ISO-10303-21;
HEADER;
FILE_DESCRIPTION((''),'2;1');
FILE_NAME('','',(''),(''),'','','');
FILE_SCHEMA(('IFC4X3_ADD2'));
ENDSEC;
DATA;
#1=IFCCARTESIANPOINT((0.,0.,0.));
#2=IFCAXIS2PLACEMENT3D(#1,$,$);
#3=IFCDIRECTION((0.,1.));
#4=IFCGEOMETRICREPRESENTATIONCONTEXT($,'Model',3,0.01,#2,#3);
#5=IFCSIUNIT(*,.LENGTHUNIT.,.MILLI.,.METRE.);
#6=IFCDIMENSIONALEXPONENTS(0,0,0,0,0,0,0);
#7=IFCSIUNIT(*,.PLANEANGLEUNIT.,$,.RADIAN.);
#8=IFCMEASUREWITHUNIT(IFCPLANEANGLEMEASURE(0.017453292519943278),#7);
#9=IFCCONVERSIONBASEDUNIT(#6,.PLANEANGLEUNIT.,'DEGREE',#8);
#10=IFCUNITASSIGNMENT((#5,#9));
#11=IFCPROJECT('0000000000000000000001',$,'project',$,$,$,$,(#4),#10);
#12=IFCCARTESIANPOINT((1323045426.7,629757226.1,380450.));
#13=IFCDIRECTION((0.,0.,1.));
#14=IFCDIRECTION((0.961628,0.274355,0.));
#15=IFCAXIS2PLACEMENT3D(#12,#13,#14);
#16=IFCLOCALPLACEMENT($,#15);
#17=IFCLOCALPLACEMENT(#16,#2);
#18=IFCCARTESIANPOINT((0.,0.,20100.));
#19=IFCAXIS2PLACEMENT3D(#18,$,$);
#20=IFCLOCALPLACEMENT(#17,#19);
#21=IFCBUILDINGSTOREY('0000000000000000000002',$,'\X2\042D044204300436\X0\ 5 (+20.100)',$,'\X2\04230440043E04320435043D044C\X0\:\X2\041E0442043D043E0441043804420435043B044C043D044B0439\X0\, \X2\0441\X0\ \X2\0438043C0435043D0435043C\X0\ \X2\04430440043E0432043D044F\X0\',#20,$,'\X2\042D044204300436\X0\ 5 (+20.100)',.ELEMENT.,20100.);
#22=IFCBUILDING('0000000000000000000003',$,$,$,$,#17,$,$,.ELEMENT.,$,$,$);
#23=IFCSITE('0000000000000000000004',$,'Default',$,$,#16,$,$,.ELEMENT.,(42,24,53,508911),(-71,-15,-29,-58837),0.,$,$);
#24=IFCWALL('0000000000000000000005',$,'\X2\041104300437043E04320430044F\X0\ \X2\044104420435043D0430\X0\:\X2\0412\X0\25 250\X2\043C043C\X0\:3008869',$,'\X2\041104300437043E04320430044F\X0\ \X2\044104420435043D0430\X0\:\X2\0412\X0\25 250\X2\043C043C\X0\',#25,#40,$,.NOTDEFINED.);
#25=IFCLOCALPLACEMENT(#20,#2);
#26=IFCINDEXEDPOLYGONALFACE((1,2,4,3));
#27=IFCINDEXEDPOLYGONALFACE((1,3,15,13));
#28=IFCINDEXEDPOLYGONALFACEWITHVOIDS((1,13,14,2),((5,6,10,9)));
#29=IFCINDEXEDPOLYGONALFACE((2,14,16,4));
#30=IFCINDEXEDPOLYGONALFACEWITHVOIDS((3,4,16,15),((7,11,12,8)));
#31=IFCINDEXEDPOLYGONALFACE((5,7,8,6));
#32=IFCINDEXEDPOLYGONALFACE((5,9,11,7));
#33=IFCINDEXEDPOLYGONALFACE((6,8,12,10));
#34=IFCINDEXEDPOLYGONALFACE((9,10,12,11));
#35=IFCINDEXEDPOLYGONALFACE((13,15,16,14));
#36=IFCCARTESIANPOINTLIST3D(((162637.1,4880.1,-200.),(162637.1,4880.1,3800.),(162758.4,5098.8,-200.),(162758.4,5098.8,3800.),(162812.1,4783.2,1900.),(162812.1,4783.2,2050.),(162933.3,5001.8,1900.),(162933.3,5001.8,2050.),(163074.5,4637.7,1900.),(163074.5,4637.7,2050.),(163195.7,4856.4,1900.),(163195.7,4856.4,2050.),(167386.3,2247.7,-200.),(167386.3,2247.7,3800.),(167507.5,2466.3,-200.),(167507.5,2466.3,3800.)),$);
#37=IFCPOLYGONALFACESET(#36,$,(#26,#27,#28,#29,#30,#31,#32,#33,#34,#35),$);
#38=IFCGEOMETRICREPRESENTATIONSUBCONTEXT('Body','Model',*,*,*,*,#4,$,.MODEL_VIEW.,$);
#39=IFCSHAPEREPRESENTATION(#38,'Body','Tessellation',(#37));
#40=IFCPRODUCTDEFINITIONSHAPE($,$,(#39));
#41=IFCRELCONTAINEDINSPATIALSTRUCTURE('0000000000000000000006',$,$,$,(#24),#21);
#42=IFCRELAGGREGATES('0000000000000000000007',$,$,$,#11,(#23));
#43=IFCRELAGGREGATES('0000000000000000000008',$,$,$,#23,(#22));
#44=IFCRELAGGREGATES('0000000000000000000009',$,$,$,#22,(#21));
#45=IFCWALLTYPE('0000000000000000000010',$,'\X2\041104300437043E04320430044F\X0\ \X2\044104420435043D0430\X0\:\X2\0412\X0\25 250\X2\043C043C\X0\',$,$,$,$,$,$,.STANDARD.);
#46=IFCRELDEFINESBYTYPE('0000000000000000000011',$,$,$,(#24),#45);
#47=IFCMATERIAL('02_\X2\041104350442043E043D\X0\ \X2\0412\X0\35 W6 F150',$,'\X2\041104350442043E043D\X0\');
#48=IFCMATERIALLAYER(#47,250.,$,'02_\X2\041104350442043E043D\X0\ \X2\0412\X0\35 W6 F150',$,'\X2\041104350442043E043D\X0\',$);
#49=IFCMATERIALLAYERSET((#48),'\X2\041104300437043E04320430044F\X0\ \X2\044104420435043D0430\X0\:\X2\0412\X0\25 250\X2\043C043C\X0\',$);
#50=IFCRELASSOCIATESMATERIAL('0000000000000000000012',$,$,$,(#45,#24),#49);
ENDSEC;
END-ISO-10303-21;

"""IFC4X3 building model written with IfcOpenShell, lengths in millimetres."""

from ifc_helpers import new_model, entity, si_unit, converted_unit, direction, frame, frame_2d, origin, place, context, subcontext, project, spatial, rectangle, extrude, material, layer, layer_set, type_object, element, save


model = new_model("IFC4X3")

# Units and contexts
model_context = context("Model", 3, precision=0.01, world=origin(), true_north=direction((0.0, 1.0)))
body_context = subcontext(model_context, "Body", "Model", "MODEL_VIEW")
ifc_project = project(units=[si_unit("LENGTHUNIT", "METRE", prefix="MILLI"), converted_unit("PLANEANGLEUNIT", "DEGREE", entity("IfcPlaneAngleMeasure", 0.017453292519943278), si_unit("PLANEANGLEUNIT", "RADIAN"), dimensions=[0, 0, 0, 0, 0, 0, 0])], contexts=[model_context])

# Site, building, storey
site_placement = place(None, frame((1323045426.7, 629757226.1, 380450.0), z_axis=(0.0, 0.0, 1.0), x_axis=(0.961628, 0.274355, 0.0)))
site = spatial("IfcSite", under=ifc_project, at=site_placement, Name="Default", CompositionType="ELEMENT", RefLatitude=(42, 24, 53, 508911), RefLongitude=(-71, -15, -29, -58837), RefElevation=0.0)
building_placement = place(site_placement, origin())
building = spatial("IfcBuilding", under=site, at=building_placement, CompositionType="ELEMENT")
storey_placement = place(building_placement, frame((0.0, 0.0, 20100.0)))
storey = spatial("IfcBuildingStorey", under=building, at=storey_placement, Name="Этаж 5 (+20.100)", ObjectType="Уровень:Относительный, с именем уровня", LongName="Этаж 5 (+20.100)", CompositionType="ELEMENT", Elevation=20100.0)

# Shared definitions
ifc_material = material(Name="02_Бетон В35 W6 F150", Category="Бетон")
ifc_layer = layer(ifc_material, 250.0, Name="02_Бетон В35 W6 F150", Category="Бетон")
ifc_layer_set = layer_set([ifc_layer], Name="Базовая стена:В25 250мм")
wall_type = type_object("IfcWallType", Name="Базовая стена:В25 250мм", PredefinedType="STANDARD", material=ifc_layer_set)

# Wall, opening
wall_1_placement = place(storey_placement, frame((167446.9, 2357.0, -200.0), z_axis=(0.0, 0.0, 1.0), x_axis=(-0.87462, 0.48481, 0.0)))
wall_1 = element("IfcWall", 1, at=wall_1_placement, inside=storey, type_object=wall_type, material=ifc_layer_set, Name="Базовая стена:В25 250мм:3008869", ObjectType="Базовая стена:В25 250мм", PredefinedType="NOTDEFINED", context=body_context, shape_type="SweptSolid", body=[
    extrude(rectangle(XDim=5429.9, YDim=250.0, at=frame_2d((2715.0, 0.0), x_axis=(-1.0, 0.0))), origin(), (0.0, 0.0, 1.0), 4000.0),
])
opening_1_placement = place(wall_1_placement, frame((145309.7, 83241.3, 2100.0), z_axis=(0.0, 0.0, 1.0), x_axis=(-0.87462, -0.48481, 0.0)))
element("IfcOpeningElement", 2, at=opening_1_placement, cuts=wall_1, PredefinedType="OPENING", context=body_context, shape_type="SweptSolid", body=[
    extrude(rectangle(XDim=150.0, YDim=300.0, at=frame_2d((0.0, 0.0), x_axis=(0.0, 1.0))), frame((163803.3, 6262.0, 75.0), z_axis=(-0.48481, -0.87462, 0.0), x_axis=(-0.87462, 0.48481, 0.0)), (0.0, 0.0, 1.0), 3048.0),
])

save(model, "model.ifc")
